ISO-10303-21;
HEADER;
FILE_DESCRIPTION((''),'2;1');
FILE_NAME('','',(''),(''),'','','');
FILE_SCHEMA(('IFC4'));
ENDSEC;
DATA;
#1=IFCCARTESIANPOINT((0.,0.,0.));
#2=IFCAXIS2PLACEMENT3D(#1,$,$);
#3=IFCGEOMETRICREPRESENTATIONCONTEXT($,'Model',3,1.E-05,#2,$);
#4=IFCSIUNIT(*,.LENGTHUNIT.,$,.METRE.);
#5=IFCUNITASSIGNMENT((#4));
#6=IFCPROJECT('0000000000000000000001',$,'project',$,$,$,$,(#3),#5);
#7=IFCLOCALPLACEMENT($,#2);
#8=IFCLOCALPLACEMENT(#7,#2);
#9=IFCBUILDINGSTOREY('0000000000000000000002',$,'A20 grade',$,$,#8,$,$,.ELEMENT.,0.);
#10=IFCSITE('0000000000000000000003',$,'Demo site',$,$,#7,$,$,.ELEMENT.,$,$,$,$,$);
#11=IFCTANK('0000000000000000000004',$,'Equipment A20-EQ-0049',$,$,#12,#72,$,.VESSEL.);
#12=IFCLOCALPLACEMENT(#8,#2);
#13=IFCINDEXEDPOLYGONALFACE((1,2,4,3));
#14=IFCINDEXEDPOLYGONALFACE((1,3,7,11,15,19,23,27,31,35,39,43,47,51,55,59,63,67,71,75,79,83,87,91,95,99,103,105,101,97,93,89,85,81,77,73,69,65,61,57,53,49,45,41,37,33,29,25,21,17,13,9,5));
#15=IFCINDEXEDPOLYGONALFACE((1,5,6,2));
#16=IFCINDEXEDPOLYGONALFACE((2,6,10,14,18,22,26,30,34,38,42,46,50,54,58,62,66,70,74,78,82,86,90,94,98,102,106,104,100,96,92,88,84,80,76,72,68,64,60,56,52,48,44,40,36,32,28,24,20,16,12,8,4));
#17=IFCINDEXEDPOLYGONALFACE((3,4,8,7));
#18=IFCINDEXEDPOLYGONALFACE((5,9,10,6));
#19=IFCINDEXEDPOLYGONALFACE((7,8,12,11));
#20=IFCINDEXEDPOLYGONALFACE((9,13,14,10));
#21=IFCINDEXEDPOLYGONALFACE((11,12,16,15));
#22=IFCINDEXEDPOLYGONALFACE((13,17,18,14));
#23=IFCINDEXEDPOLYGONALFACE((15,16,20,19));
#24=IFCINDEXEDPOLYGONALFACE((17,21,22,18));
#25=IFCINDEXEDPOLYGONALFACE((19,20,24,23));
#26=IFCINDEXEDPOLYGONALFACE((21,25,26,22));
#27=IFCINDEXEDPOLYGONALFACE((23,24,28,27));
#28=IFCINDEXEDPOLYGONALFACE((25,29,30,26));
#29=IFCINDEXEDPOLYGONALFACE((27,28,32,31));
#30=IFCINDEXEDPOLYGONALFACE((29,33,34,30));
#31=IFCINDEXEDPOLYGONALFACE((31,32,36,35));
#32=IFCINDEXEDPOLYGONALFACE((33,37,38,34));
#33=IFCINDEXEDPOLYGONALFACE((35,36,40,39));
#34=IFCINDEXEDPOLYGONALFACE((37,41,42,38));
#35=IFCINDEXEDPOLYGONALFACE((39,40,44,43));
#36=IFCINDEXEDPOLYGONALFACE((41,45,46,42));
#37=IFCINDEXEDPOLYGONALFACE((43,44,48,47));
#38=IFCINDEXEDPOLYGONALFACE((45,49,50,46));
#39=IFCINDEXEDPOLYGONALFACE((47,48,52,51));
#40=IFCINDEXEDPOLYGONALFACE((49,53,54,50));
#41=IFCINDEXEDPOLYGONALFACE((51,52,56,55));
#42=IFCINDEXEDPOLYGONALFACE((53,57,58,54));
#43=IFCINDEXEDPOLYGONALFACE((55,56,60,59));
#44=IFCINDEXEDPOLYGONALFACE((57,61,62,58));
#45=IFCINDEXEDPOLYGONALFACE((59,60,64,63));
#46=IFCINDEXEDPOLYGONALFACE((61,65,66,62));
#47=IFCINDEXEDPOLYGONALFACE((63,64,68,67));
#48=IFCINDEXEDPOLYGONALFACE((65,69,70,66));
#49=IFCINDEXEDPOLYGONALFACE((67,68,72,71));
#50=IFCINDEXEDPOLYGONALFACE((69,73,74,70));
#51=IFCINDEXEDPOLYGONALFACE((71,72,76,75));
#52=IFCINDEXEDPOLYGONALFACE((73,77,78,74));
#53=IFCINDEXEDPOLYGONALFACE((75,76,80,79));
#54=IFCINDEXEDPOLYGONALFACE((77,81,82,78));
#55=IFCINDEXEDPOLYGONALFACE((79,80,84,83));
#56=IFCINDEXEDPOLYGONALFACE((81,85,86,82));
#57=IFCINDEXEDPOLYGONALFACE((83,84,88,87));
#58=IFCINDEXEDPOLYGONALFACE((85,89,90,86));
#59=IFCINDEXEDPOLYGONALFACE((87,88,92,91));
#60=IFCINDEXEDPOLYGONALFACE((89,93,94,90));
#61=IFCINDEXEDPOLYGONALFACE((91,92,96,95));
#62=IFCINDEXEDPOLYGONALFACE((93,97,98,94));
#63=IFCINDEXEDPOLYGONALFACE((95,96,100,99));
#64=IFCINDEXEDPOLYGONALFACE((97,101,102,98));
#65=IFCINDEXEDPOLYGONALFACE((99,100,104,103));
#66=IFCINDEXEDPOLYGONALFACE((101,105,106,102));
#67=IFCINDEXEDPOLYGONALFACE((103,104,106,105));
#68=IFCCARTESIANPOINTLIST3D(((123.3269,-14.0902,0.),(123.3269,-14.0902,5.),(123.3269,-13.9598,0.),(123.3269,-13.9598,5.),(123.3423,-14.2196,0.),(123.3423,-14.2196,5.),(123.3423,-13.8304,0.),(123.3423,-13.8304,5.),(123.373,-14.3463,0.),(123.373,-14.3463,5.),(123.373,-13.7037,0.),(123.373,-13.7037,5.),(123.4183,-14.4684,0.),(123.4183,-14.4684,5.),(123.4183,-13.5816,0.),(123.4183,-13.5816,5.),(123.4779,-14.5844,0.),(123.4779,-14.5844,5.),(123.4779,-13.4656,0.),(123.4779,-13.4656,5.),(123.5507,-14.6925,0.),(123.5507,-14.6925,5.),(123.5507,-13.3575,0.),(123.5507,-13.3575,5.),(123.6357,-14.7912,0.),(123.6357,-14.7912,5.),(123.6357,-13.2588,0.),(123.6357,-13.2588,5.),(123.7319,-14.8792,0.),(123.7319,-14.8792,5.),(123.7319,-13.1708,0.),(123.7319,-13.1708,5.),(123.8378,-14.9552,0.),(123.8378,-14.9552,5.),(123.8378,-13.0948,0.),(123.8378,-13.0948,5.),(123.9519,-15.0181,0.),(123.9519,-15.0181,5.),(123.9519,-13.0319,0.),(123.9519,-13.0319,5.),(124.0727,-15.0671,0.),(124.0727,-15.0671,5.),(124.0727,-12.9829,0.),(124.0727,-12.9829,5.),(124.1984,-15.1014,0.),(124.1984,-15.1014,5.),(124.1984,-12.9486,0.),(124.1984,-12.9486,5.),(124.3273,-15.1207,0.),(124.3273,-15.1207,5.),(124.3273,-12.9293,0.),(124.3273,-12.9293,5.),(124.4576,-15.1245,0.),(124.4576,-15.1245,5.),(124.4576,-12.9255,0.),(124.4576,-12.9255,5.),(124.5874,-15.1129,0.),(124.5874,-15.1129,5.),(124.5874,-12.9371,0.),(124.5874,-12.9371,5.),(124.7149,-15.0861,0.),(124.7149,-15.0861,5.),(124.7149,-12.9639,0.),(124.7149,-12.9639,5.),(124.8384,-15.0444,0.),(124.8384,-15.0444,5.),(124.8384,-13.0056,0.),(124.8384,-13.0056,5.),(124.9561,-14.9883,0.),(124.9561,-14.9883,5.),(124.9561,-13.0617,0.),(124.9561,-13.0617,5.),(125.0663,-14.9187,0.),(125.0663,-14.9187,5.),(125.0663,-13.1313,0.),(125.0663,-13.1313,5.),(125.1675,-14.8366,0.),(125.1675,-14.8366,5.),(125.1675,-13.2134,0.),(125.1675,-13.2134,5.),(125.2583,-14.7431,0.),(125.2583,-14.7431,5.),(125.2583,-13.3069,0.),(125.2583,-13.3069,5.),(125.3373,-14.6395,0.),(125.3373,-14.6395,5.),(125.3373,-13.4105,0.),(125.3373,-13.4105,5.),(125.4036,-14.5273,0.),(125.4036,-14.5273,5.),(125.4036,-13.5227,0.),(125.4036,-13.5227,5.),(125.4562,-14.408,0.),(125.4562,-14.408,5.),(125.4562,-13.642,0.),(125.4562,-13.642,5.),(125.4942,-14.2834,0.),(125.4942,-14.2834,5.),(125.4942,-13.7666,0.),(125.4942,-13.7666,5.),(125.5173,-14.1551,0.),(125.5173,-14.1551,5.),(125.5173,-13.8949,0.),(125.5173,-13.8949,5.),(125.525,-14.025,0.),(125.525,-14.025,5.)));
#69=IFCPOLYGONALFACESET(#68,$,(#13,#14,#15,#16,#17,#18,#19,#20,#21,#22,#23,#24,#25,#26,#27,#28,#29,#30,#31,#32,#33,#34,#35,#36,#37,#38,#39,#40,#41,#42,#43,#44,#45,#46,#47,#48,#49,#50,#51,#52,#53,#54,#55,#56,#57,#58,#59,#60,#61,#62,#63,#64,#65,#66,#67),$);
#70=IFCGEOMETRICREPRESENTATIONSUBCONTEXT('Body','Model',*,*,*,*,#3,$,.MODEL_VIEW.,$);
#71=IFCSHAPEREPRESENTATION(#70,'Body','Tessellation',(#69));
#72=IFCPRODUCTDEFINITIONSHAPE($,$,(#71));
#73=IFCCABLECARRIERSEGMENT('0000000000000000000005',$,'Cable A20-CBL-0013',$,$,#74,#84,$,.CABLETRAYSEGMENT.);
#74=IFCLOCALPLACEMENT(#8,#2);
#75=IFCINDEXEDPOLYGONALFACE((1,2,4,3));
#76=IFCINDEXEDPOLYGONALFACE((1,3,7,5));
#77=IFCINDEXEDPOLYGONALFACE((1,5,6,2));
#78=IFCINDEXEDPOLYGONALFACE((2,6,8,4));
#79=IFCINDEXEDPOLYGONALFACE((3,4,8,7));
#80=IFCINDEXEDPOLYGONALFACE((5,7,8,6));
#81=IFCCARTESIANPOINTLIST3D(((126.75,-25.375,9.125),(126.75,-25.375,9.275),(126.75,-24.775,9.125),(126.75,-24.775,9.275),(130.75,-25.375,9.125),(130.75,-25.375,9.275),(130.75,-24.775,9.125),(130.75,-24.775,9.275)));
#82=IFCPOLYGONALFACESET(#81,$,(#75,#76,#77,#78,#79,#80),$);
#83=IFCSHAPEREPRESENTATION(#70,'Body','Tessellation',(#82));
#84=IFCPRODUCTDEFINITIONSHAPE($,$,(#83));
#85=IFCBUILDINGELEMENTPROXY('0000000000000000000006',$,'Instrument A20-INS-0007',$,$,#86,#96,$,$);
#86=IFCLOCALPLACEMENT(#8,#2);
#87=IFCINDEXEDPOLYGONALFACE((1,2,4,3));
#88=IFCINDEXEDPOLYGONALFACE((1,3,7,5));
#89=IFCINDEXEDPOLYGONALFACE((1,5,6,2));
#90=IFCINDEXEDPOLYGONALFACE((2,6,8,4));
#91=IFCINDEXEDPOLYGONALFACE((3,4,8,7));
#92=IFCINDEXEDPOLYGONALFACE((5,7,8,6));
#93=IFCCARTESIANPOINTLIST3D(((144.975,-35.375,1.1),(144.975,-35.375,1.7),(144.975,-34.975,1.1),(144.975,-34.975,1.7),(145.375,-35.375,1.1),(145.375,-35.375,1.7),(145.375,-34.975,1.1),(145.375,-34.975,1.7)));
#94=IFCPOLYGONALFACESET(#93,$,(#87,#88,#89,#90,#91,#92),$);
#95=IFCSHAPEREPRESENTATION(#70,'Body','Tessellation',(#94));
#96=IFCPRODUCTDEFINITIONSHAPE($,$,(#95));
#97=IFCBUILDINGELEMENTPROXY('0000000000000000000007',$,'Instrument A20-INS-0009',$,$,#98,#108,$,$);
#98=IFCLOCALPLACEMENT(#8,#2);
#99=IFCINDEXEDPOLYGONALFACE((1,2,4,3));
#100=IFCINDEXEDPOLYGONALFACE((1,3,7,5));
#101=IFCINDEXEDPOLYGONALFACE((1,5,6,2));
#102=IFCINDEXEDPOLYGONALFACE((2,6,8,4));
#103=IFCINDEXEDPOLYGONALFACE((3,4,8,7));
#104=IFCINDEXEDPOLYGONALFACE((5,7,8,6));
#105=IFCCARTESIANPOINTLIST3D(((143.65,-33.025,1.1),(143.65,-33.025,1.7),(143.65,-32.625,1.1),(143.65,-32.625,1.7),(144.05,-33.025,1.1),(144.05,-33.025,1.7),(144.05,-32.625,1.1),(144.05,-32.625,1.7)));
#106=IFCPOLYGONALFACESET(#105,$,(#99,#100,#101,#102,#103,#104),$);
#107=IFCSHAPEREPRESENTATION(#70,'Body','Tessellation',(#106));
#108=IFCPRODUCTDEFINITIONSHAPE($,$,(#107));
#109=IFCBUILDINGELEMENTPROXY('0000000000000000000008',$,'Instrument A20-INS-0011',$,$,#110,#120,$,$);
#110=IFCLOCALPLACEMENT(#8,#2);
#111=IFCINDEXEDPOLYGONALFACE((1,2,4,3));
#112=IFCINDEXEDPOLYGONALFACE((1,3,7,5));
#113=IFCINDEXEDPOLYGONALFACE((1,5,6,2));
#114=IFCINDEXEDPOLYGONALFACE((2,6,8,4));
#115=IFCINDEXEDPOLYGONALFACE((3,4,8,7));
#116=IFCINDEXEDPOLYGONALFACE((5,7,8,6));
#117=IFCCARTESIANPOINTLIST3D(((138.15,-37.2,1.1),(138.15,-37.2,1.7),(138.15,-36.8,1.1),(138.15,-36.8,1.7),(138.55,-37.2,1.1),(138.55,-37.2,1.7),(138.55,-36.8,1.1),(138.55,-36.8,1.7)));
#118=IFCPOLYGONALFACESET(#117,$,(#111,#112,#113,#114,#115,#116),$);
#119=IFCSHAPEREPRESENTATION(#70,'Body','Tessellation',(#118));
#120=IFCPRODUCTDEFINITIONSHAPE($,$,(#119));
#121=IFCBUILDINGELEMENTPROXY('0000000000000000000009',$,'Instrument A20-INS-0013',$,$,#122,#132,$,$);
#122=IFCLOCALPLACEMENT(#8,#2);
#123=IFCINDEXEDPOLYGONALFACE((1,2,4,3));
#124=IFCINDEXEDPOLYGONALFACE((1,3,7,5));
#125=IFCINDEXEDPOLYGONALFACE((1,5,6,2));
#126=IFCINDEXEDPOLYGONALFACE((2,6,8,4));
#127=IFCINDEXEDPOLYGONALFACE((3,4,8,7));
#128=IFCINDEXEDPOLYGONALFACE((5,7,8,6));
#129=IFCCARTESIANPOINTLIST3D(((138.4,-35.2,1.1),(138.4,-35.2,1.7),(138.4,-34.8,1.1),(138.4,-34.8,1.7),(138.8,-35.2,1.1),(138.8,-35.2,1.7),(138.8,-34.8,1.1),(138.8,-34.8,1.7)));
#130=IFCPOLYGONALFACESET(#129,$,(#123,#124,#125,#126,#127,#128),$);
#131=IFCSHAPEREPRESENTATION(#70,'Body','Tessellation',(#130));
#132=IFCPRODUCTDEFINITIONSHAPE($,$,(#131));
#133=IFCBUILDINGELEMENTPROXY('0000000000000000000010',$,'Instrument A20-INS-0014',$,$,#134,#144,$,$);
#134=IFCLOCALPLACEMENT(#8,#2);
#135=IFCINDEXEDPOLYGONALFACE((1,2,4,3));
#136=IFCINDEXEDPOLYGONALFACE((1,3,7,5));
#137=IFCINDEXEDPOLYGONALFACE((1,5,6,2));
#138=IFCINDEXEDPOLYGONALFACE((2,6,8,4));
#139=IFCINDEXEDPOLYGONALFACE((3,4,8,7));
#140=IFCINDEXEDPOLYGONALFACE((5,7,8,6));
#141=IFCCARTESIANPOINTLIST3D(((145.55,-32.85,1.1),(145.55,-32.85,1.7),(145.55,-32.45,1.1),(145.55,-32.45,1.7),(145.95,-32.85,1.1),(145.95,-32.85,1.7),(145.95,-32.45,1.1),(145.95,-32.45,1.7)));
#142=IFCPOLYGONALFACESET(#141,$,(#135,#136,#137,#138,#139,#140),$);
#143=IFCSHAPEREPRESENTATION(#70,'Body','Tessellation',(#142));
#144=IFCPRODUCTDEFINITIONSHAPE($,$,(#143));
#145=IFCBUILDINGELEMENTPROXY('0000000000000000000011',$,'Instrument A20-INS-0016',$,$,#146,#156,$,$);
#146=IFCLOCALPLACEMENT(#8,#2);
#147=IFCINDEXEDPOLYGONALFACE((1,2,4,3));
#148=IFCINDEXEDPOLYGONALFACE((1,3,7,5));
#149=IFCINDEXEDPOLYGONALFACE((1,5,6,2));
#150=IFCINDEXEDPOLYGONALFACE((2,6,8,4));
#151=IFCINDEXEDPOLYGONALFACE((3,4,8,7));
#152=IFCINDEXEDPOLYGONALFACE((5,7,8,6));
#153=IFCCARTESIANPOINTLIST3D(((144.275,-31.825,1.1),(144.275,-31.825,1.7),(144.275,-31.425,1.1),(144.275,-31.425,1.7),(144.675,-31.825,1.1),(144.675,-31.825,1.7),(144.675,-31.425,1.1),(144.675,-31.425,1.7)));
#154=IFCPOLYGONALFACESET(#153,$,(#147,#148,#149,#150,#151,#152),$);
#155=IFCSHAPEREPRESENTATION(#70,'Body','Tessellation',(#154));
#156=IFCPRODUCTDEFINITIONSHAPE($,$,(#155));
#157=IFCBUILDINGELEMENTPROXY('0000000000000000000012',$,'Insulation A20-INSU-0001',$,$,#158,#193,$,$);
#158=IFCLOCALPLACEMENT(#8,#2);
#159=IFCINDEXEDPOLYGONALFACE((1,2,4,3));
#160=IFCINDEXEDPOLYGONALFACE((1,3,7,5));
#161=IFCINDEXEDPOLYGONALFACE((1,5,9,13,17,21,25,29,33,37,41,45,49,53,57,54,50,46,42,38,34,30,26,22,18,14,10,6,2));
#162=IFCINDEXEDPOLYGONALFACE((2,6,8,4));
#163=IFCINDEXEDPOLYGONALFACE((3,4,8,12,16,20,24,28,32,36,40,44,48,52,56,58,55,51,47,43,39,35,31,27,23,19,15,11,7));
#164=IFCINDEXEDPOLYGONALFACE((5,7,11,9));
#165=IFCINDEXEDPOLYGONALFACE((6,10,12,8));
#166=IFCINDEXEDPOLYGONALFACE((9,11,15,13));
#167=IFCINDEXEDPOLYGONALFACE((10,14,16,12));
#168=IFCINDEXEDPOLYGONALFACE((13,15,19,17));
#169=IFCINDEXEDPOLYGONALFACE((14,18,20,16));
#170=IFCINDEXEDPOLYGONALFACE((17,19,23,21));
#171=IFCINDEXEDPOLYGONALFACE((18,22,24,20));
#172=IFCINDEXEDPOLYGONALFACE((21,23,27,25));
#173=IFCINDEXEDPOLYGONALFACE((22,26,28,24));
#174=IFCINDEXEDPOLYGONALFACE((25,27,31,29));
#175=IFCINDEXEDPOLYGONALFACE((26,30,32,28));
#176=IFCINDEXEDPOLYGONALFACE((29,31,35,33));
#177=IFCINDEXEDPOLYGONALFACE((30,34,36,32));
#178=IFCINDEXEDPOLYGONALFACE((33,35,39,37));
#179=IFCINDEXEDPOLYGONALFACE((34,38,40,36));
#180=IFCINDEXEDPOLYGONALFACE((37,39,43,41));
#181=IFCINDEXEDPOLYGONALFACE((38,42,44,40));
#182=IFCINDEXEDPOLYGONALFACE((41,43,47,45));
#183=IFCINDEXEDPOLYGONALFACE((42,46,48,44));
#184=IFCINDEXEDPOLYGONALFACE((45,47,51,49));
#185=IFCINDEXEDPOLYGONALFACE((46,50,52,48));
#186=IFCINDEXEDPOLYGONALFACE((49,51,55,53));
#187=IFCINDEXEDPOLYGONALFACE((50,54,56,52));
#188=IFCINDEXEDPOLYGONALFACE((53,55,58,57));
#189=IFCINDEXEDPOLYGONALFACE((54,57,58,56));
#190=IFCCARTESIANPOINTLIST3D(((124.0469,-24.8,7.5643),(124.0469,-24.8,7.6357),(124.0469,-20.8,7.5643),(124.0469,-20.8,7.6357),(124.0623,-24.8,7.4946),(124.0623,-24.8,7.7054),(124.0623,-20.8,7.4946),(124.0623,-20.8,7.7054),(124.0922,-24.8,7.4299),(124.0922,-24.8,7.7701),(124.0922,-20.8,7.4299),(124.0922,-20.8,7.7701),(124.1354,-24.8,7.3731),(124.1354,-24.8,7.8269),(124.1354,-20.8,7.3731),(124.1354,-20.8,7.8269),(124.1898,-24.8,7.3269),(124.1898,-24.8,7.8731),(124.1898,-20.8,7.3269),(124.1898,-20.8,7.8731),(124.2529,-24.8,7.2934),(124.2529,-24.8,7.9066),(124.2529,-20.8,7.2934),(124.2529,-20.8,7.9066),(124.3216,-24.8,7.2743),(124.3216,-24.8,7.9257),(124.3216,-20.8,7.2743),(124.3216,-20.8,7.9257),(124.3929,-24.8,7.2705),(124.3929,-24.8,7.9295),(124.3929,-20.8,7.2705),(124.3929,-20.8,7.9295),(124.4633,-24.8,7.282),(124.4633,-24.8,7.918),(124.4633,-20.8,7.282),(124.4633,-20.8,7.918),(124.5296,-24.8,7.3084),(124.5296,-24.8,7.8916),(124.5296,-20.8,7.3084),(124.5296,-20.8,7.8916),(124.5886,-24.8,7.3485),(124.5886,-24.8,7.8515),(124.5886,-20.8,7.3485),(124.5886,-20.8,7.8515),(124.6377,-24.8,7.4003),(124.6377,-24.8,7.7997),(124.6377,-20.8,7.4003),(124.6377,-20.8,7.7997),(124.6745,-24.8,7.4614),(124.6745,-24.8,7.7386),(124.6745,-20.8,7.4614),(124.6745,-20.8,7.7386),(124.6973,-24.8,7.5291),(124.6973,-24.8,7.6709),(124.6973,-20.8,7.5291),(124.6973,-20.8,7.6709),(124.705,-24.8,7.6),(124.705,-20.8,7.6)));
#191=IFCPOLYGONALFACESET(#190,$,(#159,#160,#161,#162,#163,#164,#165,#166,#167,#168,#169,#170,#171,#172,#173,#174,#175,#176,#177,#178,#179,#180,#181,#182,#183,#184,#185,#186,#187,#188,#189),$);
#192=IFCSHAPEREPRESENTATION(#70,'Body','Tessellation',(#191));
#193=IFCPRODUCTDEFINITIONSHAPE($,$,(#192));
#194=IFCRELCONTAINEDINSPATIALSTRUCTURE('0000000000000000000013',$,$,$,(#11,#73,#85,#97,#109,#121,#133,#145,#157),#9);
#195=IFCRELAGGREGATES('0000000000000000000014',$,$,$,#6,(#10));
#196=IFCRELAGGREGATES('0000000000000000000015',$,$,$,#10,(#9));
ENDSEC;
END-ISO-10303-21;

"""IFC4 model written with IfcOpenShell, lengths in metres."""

from ifc_helpers import new_model, si_unit, frame, origin, place, context, subcontext, project, spatial, rectangle, circle, extrude, element, save


model = new_model("IFC4")

# Units and contexts
model_context = context("Model", 3, precision=1e-05, world=origin())
body_context = subcontext(model_context, "Body", "Model", "MODEL_VIEW")
ifc_project = project(units=[si_unit("LENGTHUNIT", "METRE")], contexts=[model_context])

# Site, storey
site_placement = place(None, origin())
site = spatial("IfcSite", under=ifc_project, at=site_placement, Name="Demo site", CompositionType="ELEMENT")
storey_placement = place(site_placement, origin())
storey = spatial("IfcBuildingStorey", under=site, at=storey_placement, Name="A20 grade", CompositionType="ELEMENT", Elevation=0.0)

# Tank
for number, where, name in (
    (1, (124.425, -14.025, 0.0), "Equipment A20-EQ-0049"),
):
    element("IfcTank", number, at=place(storey_placement, frame(where)), inside=storey, Name=name, PredefinedType="VESSEL", context=body_context, shape_type="SweptSolid", body=[
        extrude(circle(Radius=1.1), origin(), (0.0, 0.0, 1.0), 5.0),
    ])

# Cable carrier segment
cable_carrier_segment_placement = place(storey_placement, frame((126.75, -25.075, 9.2)))
element("IfcCableCarrierSegment", 2, at=cable_carrier_segment_placement, inside=storey, Name="Cable A20-CBL-0013", PredefinedType="CABLETRAYSEGMENT", context=body_context, shape_type="SweptSolid", body=[
    extrude(rectangle(XDim=0.6, YDim=0.15), frame((0.0, 0.0, 0.0), z_axis=(1.0, 0.0, 0.0), x_axis=(0.0, 1.0, 0.0)), (0.0, 0.0, 1.0), 4.0),
])

# Building element proxies
for number, where, name in (
    (3, (145.175, -35.175, 1.1), "Instrument A20-INS-0007"),
    (4, (143.85, -32.825, 1.1), "Instrument A20-INS-0009"),
    (5, (138.35, -37.0, 1.1), "Instrument A20-INS-0011"),
    (6, (138.6, -35.0, 1.1), "Instrument A20-INS-0013"),
    (7, (145.75, -32.65, 1.1), "Instrument A20-INS-0014"),
    (8, (144.475, -31.625, 1.1), "Instrument A20-INS-0016"),
):
    element("IfcBuildingElementProxy", number, at=place(storey_placement, frame(where)), inside=storey, Name=name, context=body_context, shape_type="SweptSolid", body=[
        extrude(rectangle(XDim=0.4, YDim=0.4), origin(), (0.0, 0.0, 1.0), 0.6),
    ])
for number, where, name in (
    (9, (124.375, -24.8, 7.6), "Insulation A20-INSU-0001"),
):
    element("IfcBuildingElementProxy", number, at=place(storey_placement, frame(where)), inside=storey, Name=name, context=body_context, shape_type="SweptSolid", body=[
        extrude(circle(Radius=0.33), frame((0.0, 0.0, 0.0), z_axis=(0.0, 1.0, 0.0), x_axis=(1.0, 0.0, 0.0)), (0.0, 0.0, 1.0), 4.0),
    ])

save(model, "model.ifc")
